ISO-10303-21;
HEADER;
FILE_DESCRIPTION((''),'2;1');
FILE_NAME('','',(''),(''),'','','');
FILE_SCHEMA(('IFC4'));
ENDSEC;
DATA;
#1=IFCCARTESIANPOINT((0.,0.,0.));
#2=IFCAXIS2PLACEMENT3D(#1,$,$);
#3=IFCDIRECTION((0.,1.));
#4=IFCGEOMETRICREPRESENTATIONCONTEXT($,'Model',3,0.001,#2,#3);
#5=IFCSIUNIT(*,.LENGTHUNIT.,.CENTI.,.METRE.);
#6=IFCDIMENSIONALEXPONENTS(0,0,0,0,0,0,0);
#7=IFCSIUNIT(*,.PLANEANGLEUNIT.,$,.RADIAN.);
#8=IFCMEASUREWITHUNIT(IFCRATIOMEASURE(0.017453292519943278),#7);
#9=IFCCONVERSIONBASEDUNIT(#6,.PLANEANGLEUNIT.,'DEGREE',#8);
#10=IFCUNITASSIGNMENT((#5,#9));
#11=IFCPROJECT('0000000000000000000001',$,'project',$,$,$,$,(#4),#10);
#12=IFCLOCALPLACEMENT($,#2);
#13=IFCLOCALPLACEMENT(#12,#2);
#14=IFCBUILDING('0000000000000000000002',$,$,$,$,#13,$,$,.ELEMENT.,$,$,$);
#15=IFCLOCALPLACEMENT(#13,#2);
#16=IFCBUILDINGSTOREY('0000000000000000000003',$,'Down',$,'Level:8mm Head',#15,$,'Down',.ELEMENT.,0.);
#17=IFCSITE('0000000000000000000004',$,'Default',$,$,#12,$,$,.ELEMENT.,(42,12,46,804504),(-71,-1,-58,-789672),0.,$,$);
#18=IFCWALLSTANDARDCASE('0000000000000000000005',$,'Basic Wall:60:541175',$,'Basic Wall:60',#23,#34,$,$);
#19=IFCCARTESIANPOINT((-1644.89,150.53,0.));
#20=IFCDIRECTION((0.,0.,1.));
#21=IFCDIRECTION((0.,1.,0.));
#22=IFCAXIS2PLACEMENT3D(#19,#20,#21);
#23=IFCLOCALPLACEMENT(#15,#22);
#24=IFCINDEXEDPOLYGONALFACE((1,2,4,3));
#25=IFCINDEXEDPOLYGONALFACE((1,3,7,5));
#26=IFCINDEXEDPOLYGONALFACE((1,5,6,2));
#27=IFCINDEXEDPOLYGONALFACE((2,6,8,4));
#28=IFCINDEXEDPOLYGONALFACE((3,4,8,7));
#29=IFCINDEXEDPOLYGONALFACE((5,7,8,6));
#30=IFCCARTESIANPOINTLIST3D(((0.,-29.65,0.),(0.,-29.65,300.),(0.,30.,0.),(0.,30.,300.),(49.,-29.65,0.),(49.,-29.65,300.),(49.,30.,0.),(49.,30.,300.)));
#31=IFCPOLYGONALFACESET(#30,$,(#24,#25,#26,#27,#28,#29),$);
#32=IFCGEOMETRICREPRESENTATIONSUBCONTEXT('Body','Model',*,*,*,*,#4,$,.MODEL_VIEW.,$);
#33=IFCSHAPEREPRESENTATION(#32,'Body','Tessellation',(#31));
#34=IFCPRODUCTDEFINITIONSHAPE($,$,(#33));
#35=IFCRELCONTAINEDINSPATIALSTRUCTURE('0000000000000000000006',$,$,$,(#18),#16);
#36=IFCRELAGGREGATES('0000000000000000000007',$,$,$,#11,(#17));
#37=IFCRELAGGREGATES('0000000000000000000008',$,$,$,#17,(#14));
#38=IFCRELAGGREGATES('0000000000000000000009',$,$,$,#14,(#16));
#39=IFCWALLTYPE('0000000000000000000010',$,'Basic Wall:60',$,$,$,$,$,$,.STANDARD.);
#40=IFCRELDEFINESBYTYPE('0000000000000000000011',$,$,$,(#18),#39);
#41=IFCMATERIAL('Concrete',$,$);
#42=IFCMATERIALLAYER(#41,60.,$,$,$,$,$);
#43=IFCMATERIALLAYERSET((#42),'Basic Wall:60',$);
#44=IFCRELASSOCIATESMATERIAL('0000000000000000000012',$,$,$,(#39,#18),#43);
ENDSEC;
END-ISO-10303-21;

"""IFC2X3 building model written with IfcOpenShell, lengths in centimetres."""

from ifc_helpers import new_model, entity, si_unit, converted_unit, direction, frame, frame_2d, origin, place, context, subcontext, project, spatial, polyline, rectangle, extrude, clip, bounded_halfspace, material, layer, layer_set, layer_usage, type_object, element, save


model = new_model("IFC2X3")

# Units and contexts
model_context = context("Model", 3, precision=0.001, world=origin(), true_north=direction((0.0, 1.0)))
body_context = subcontext(model_context, "Body", "Model", "MODEL_VIEW")
ifc_project = project(units=[si_unit("LENGTHUNIT", "METRE", prefix="CENTI"), converted_unit("PLANEANGLEUNIT", "DEGREE", entity("IfcRatioMeasure", 0.017453292519943278), si_unit("PLANEANGLEUNIT", "RADIAN"), dimensions=[0, 0, 0, 0, 0, 0, 0])], contexts=[model_context])

# Site, building, storey
site_placement = place(None, origin())
site = spatial("IfcSite", under=ifc_project, at=site_placement, Name="Default", CompositionType="ELEMENT", RefLatitude=(42, 12, 46, 804504), RefLongitude=(-71, -1, -58, -789672), RefElevation=0.0)
building_placement = place(site_placement, origin())
building = spatial("IfcBuilding", under=site, at=building_placement, CompositionType="ELEMENT")
storey_placement = place(building_placement, origin())
storey = spatial("IfcBuildingStorey", under=building, at=storey_placement, Name="Down", ObjectType="Level:8mm Head", LongName="Down", CompositionType="ELEMENT", Elevation=0.0)

# Shared definitions
ifc_material = material(Name="Concrete")

# Wall
ifc_layer_1 = layer(ifc_material, 60.0)
ifc_layer_set_1 = layer_set([ifc_layer_1], Name="Basic Wall:60")
ifc_layer_usage_1 = layer_usage(ifc_layer_set_1, "AXIS2", "POSITIVE", -30.0)
wall_type_1 = type_object("IfcWallType", Name="Basic Wall:60", PredefinedType="STANDARD", material=ifc_layer_set_1)
wall_1_placement = place(storey_placement, frame((-1644.89, 150.53, 0.0), z_axis=(0.0, 0.0, 1.0), x_axis=(0.0, 1.0, 0.0)))
element("IfcWallStandardCase", 1, at=wall_1_placement, inside=storey, type_object=wall_type_1, material=ifc_layer_usage_1, Name="Basic Wall:60:541175", ObjectType="Basic Wall:60", context=body_context, shape_type="Clipping", body=[
    clip(extrude(rectangle(XDim=49.0, YDim=60.0, at=frame_2d((24.5, 0.0), x_axis=(-1.0, 0.0))), origin(), (0.0, 0.0, 1.0), 300.0), bounded_halfspace(frame((49.0, -29.65, 0.0), z_axis=(0.0, 1.0, 0.0), x_axis=(-1.0, 0.0, 0.0)), True, frame((49.0, -29.65, 0.0), z_axis=(0.0, 1.0, 0.0), x_axis=(-1.0, 0.0, 0.0)), polyline([(0.0, 0.0), (24.0, 0.0), (49.0, 0.0), (49.0, 300.0), (24.0, 300.0), (0.0, 300.0), (0.0, 0.0)]))),
])

save(model, "model.ifc")
